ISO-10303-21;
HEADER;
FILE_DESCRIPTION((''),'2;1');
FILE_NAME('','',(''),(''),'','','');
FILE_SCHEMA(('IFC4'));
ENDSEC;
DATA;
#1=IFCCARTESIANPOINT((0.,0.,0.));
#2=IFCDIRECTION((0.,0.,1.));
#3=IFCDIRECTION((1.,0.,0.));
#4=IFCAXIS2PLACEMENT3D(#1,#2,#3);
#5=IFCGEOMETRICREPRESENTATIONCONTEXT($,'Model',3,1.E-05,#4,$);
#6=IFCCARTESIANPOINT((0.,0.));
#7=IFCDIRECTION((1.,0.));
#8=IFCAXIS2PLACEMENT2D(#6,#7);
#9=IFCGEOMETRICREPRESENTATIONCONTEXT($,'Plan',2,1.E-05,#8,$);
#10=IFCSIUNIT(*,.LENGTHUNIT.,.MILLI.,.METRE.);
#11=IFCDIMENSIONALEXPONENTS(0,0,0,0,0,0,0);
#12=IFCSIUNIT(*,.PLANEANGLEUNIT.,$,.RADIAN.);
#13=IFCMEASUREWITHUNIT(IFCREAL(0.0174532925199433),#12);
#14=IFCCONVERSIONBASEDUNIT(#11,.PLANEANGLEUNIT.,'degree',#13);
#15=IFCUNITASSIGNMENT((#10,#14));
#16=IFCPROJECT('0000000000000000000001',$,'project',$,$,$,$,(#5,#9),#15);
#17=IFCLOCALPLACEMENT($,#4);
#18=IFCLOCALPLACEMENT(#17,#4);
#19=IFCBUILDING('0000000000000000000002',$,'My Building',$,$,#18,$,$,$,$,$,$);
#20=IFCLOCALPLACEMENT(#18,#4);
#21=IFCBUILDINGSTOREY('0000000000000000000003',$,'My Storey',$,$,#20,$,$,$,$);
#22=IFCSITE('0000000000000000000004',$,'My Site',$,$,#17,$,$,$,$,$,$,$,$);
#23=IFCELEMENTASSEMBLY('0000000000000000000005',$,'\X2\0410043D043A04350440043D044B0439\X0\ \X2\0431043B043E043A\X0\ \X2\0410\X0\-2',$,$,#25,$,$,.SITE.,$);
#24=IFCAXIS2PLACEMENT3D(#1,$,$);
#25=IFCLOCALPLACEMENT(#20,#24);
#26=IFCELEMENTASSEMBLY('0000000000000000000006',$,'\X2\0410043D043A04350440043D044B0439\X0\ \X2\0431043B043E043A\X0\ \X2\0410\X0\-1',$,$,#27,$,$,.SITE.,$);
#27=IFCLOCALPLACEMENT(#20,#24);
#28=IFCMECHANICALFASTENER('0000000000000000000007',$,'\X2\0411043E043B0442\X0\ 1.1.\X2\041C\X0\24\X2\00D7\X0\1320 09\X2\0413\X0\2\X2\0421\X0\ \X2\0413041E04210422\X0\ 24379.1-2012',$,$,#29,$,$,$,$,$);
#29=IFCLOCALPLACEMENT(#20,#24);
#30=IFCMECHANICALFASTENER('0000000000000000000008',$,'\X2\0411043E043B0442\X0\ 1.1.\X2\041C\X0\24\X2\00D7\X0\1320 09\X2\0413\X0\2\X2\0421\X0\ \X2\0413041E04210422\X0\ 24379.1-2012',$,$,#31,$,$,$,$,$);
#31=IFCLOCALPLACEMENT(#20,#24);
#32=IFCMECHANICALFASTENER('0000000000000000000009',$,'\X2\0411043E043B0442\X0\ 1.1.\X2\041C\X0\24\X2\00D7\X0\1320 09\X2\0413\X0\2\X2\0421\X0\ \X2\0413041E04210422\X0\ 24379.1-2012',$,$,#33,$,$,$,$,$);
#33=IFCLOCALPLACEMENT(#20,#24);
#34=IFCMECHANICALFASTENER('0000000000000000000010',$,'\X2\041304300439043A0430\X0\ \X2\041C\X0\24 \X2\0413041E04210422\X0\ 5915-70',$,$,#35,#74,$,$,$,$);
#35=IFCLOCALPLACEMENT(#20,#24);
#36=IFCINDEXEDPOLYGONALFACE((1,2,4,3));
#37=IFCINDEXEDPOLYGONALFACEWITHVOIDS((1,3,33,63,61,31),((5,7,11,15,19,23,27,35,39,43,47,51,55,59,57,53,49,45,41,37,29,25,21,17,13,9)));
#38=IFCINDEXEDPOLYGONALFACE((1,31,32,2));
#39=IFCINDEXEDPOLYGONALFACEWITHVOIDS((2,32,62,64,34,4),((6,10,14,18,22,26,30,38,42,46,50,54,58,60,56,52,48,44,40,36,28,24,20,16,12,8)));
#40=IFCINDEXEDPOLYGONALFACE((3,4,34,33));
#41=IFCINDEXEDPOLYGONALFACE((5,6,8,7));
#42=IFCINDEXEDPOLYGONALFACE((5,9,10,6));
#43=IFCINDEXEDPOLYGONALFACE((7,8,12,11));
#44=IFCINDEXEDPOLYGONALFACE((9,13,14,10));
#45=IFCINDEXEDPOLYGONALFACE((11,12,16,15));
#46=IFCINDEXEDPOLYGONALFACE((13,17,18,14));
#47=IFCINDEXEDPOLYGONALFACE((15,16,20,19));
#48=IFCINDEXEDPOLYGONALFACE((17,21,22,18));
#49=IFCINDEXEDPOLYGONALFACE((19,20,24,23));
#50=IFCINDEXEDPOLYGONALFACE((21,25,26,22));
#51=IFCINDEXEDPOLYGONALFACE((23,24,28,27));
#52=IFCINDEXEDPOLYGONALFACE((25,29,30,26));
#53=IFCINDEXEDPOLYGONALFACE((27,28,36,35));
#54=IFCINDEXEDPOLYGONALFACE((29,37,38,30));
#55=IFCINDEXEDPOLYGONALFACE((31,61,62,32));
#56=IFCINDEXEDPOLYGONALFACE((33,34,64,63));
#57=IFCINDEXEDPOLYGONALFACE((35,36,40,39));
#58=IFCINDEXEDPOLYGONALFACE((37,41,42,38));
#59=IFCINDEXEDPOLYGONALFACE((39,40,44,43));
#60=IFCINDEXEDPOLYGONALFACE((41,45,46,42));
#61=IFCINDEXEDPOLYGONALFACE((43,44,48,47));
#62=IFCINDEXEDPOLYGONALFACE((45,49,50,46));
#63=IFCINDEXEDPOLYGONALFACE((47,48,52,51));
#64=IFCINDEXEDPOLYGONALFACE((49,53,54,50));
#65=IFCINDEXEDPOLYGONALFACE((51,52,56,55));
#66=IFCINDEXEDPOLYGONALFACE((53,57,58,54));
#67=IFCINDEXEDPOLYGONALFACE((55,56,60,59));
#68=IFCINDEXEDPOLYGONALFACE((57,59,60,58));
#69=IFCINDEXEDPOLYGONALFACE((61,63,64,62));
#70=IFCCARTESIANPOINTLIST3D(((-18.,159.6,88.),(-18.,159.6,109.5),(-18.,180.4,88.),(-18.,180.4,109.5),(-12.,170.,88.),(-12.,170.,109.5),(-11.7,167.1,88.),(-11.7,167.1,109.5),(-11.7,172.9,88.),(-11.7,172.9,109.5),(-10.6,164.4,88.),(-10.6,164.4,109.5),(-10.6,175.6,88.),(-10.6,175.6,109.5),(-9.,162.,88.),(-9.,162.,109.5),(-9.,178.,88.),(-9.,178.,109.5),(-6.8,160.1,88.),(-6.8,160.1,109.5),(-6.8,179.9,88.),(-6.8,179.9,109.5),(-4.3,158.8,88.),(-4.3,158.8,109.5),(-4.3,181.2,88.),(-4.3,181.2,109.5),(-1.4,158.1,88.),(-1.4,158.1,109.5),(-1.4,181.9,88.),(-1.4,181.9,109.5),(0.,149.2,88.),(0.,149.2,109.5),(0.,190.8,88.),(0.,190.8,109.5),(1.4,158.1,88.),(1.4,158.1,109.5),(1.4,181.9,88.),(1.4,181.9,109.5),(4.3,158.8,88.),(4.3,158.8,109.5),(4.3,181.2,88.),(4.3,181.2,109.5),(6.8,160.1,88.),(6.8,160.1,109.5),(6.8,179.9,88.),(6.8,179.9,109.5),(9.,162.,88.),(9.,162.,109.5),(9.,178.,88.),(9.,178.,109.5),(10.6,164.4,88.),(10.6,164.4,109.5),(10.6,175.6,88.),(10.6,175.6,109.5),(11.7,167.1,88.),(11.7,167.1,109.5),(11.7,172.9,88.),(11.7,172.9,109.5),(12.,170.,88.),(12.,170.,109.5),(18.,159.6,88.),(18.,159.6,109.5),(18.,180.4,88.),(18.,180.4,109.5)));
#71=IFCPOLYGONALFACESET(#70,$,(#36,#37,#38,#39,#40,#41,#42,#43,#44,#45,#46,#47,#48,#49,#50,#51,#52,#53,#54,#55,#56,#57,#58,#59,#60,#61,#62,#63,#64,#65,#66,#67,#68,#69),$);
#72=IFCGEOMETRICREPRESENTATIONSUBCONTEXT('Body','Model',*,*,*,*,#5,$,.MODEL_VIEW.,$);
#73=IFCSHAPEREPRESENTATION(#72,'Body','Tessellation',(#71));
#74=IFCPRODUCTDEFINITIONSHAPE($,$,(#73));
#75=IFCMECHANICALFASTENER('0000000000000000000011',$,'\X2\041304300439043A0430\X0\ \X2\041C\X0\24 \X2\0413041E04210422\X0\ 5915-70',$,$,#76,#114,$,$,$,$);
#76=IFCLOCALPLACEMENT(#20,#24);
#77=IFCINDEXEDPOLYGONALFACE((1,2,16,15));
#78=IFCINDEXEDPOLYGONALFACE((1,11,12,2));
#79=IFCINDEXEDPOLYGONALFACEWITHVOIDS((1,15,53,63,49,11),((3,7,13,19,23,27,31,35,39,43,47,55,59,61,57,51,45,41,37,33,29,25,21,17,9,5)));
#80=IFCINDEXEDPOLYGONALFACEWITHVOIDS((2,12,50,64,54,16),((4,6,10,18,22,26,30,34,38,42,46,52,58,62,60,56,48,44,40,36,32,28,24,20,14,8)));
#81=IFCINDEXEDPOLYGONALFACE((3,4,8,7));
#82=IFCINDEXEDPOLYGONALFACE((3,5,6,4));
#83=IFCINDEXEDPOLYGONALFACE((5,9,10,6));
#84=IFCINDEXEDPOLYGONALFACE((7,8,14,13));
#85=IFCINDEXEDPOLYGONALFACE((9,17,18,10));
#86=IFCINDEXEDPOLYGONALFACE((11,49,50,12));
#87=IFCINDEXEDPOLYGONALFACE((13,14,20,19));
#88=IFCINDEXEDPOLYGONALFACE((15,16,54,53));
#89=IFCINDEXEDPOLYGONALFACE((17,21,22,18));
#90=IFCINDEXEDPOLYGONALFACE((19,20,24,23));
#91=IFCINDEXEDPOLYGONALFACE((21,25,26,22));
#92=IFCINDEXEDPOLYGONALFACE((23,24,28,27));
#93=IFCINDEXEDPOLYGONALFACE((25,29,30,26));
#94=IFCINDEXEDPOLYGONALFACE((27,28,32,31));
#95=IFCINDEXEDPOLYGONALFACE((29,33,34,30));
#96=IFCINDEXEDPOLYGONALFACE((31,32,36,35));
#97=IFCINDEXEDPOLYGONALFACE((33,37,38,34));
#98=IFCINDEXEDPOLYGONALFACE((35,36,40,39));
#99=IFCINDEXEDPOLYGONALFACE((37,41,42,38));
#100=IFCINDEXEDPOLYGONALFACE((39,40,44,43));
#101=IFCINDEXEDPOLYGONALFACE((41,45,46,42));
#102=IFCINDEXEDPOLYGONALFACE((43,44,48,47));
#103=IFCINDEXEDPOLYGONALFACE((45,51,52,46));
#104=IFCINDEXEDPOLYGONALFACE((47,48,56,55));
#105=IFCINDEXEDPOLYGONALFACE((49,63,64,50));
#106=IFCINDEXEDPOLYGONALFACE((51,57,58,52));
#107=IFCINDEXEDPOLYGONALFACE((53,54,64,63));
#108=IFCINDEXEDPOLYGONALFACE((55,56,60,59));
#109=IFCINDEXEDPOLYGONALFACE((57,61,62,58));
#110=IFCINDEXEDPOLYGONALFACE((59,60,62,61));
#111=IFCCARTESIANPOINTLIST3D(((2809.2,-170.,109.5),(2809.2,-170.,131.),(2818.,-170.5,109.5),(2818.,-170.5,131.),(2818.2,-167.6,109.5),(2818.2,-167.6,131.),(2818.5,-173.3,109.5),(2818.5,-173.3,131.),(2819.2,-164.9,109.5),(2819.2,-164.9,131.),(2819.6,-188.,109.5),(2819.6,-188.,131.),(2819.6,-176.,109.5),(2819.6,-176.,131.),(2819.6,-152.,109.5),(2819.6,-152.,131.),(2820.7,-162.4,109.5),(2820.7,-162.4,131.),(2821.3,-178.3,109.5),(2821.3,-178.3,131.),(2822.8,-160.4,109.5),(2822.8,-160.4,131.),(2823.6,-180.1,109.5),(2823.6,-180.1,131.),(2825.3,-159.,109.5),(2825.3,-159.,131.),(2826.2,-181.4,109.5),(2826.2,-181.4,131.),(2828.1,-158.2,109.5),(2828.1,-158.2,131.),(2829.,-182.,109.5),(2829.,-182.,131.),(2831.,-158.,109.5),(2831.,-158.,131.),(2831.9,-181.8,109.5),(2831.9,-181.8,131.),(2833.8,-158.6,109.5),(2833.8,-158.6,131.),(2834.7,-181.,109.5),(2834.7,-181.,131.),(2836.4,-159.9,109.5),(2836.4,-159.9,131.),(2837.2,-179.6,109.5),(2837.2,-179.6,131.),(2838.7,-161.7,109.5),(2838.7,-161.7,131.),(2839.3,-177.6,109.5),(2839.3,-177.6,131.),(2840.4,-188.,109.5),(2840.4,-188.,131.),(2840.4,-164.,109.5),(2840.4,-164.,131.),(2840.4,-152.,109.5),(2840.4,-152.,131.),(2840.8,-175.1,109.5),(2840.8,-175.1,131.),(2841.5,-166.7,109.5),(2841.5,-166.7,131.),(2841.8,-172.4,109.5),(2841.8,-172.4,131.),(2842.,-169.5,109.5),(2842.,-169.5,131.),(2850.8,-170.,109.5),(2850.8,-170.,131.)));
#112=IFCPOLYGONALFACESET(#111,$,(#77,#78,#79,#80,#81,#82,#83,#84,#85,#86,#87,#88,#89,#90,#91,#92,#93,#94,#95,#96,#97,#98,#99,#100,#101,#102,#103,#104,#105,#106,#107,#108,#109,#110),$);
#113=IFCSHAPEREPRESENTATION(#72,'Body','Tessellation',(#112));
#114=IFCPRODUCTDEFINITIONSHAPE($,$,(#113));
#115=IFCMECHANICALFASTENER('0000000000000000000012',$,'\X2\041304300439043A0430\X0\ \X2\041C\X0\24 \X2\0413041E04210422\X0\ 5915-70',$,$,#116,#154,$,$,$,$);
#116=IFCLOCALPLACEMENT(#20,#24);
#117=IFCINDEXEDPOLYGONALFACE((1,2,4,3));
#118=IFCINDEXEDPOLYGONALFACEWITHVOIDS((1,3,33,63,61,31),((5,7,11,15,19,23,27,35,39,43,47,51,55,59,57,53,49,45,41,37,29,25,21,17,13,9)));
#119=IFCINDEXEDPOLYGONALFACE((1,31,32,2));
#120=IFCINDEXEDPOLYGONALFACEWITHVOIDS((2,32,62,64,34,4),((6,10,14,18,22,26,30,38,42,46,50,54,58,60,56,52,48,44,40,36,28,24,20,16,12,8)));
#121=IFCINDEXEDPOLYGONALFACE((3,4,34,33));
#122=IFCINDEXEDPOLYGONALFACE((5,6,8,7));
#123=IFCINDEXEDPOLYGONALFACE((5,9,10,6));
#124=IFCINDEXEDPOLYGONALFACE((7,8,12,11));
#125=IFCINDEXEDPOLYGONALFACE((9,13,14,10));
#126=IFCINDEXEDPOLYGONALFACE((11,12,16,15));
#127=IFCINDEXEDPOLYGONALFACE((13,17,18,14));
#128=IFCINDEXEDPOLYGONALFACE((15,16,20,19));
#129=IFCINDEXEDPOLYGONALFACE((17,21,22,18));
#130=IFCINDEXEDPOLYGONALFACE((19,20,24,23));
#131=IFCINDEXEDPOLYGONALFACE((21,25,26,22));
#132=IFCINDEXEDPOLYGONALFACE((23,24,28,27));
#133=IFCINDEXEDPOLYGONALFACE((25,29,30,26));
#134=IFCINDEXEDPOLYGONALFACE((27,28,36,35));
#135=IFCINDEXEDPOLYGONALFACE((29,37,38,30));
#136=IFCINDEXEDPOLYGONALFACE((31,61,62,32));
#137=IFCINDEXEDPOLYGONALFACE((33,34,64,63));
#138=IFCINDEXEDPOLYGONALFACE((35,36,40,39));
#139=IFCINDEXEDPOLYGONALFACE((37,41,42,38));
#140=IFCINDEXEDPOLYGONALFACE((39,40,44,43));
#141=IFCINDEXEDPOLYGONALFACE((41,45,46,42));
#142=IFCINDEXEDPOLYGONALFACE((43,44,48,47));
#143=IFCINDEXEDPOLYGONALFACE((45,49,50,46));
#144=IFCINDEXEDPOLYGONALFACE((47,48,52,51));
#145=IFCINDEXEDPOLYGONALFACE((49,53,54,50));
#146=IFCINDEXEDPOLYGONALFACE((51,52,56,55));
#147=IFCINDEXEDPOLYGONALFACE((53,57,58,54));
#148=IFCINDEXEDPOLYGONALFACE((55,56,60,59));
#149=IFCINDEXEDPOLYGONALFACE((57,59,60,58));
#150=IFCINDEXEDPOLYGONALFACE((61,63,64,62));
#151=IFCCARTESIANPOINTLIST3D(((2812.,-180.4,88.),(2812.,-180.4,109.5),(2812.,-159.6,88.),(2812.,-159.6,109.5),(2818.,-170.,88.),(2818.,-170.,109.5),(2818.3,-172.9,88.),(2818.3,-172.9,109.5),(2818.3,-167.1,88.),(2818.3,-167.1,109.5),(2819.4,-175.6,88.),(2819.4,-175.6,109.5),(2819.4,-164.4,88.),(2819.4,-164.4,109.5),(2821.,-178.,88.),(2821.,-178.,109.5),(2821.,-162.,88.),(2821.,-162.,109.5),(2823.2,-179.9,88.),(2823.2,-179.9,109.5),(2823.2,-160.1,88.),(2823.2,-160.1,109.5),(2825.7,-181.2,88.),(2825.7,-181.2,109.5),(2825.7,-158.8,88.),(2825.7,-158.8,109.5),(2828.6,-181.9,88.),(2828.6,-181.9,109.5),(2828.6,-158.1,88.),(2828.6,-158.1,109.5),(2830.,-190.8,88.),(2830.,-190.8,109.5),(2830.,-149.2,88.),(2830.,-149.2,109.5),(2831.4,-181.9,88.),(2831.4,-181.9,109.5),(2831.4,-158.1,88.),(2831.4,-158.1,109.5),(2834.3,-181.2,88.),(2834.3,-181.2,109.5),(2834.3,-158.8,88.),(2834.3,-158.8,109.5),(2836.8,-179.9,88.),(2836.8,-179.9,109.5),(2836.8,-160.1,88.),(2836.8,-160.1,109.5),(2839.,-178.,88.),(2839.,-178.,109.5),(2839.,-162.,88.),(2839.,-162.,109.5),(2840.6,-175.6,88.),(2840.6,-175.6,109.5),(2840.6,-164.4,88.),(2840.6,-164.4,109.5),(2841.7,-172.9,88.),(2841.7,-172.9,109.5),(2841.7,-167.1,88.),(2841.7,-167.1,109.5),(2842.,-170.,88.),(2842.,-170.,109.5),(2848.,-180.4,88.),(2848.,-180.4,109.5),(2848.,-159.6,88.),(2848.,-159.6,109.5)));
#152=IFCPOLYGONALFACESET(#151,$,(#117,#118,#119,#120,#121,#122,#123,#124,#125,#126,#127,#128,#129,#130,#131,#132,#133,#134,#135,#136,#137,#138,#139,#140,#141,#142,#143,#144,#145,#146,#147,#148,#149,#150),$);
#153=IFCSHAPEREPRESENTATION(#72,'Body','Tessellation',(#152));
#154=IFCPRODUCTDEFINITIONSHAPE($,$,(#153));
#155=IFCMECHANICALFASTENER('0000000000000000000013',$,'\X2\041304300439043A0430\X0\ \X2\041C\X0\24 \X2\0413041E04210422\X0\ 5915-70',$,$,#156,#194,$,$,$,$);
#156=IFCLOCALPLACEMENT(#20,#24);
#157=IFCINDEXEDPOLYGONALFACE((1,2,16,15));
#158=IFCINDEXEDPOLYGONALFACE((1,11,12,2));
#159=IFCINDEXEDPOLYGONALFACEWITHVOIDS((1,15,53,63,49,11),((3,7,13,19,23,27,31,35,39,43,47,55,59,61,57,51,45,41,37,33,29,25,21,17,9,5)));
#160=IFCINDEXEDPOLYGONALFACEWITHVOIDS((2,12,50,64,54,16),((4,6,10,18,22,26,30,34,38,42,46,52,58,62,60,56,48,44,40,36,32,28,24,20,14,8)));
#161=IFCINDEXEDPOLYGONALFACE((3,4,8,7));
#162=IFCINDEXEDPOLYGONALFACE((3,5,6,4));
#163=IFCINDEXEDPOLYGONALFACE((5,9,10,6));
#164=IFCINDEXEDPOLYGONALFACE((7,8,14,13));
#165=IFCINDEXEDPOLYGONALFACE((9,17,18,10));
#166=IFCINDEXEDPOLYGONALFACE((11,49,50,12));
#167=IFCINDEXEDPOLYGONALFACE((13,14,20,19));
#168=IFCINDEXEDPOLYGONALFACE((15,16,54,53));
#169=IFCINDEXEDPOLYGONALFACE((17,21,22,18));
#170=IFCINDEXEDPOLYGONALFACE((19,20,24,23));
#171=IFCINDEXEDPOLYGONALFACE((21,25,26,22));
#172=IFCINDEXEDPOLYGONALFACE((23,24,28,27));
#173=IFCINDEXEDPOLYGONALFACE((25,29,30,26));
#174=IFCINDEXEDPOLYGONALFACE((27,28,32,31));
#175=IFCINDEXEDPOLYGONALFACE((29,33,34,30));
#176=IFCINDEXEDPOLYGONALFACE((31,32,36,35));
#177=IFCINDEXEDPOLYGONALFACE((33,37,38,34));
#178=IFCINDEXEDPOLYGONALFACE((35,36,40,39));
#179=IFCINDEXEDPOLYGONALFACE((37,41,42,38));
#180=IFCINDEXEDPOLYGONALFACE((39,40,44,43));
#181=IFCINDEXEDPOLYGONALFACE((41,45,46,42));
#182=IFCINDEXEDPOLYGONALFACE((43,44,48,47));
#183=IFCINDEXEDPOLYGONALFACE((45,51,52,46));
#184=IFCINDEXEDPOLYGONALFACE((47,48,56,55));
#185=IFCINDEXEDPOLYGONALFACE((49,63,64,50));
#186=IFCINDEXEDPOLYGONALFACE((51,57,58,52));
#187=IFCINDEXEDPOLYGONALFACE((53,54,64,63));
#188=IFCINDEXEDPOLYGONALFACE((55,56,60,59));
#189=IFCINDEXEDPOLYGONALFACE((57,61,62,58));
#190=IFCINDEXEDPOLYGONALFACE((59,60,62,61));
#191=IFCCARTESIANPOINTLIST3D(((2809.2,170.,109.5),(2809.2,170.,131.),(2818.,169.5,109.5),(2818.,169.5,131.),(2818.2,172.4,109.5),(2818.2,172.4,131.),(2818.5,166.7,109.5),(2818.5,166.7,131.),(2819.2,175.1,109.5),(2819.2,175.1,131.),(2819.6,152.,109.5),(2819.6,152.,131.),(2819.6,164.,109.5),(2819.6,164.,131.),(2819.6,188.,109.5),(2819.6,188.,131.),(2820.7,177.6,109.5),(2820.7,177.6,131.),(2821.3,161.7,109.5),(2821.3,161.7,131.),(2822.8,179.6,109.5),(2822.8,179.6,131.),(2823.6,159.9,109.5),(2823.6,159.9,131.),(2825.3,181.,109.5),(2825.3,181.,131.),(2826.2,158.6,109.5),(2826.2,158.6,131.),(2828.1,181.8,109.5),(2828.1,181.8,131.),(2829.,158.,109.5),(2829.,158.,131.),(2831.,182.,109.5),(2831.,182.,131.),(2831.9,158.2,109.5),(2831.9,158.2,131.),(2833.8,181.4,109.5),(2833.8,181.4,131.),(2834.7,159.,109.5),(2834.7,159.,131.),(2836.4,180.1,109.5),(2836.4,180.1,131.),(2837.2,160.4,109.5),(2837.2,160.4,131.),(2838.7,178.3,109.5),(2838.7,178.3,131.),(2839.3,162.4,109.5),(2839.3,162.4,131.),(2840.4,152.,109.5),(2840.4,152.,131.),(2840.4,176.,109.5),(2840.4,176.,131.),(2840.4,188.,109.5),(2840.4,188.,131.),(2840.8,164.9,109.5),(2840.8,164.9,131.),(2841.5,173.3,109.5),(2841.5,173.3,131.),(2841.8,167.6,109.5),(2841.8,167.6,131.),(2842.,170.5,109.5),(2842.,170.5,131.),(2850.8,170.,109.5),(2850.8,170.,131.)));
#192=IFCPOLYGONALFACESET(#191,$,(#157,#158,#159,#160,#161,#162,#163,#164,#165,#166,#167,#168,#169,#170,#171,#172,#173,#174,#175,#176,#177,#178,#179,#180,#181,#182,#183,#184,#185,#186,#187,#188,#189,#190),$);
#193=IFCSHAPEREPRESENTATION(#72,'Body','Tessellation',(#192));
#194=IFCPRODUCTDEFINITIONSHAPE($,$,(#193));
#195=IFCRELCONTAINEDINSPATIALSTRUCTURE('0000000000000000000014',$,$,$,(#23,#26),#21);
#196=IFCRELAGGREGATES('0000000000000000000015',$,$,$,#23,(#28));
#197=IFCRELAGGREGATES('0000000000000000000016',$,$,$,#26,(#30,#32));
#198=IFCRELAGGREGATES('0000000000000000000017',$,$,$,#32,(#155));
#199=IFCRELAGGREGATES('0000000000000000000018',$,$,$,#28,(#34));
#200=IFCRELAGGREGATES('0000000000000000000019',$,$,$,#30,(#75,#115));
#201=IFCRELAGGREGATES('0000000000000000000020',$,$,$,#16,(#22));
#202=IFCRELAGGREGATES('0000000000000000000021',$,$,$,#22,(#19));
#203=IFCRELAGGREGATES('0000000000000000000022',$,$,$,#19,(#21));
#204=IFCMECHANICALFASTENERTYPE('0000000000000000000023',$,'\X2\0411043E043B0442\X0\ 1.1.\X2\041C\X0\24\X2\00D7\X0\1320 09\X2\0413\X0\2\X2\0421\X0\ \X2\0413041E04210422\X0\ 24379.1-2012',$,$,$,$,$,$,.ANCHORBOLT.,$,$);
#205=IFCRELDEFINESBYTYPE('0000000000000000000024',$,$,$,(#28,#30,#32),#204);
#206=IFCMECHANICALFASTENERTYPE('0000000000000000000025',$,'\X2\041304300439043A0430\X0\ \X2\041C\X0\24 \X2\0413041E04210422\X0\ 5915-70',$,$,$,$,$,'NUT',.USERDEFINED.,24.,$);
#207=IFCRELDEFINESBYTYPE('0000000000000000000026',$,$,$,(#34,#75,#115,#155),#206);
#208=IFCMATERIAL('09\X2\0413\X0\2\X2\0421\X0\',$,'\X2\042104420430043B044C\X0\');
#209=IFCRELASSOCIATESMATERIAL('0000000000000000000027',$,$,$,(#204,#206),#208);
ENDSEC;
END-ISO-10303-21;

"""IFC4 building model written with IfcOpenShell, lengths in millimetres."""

from ifc_helpers import new_model, entity, si_unit, converted_unit, frame, origin_with_axes, origin_2d_with_axis, place, context, subcontext, project, spatial, polyline, outline, extrude, source, transform, mapped, material, type_object, type_shapes, element, aggregate, save


model = new_model("IFC4")

# Units and contexts
model_context = context("Model", 3, precision=1e-05, world=origin_with_axes())
plan_context = context("Plan", 2, precision=1e-05, world=origin_2d_with_axis())
body_context = subcontext(model_context, "Body", "Model", "MODEL_VIEW")
ifc_project = project(units=[si_unit("LENGTHUNIT", "METRE", prefix="MILLI"), converted_unit("PLANEANGLEUNIT", "degree", entity("IfcReal", 0.0174532925199433), si_unit("PLANEANGLEUNIT", "RADIAN"), dimensions=[0, 0, 0, 0, 0, 0, 0])], contexts=[model_context, plan_context])

# Site, building, storey
site_placement = place(None, origin_with_axes())
site = spatial("IfcSite", under=ifc_project, at=site_placement, Name="My Site")
building_placement = place(site_placement, origin_with_axes())
building = spatial("IfcBuilding", under=site, at=building_placement, Name="My Building")
storey_placement = place(building_placement, origin_with_axes())
storey = spatial("IfcBuildingStorey", under=building, at=storey_placement, Name="My Storey")

# Element assemblies
placement_1 = place(storey_placement, origin_with_axes())
assembly_1 = element("IfcElementAssembly", 1, at=placement_1, inside=storey, Name="Анкерный блок А-2", AssemblyPlace="SITE")
placement_2 = place(storey_placement, frame((3000.0, 0.0, 0.0), z_axis=(0.0, 0.0, 1.0), x_axis=(1.0, 0.0, 0.0)))
assembly_2 = element("IfcElementAssembly", 2, at=placement_2, inside=storey, Name="Анкерный блок А-1", AssemblyPlace="SITE")

# Shared definitions
ifc_material_1 = material(Name="09Г2С", Category="Сталь")
mechanical_fastener_type_1 = type_object("IfcMechanicalFastenerType", Name="Болт 1.1.М24×1320 09Г2С ГОСТ 24379.1-2012", PredefinedType="ANCHORBOLT", material=ifc_material_1)

# Mechanical fastener
mechanical_fastener_1_placement = place(placement_1, frame((0.0, 170.0, 0.0), z_axis=(0.0, 0.0, 1.0), x_axis=(-1.0, 0.0, 0.0)))
mechanical_fastener_1 = element("IfcMechanicalFastener", 3, at=mechanical_fastener_1_placement, type_object=mechanical_fastener_type_1, Name="Болт 1.1.М24×1320 09Г2С ГОСТ 24379.1-2012")
aggregate(assembly_1, [mechanical_fastener_1])

# Mechanical fasteners
mechanical_fastener_2_placement = place(placement_2, frame((-170.0, -170.0, 0.0), z_axis=(0.0, 0.0, 1.0), x_axis=(1.0, 0.0, 0.0)))
mechanical_fastener_2 = element("IfcMechanicalFastener", 4, at=mechanical_fastener_2_placement, type_object=mechanical_fastener_type_1, Name="Болт 1.1.М24×1320 09Г2С ГОСТ 24379.1-2012")
mechanical_fastener_3_placement = place(placement_2, frame((-170.0, 170.0, 0.0), z_axis=(0.0, 0.0, 1.0), x_axis=(-1.0, 0.0, 0.0)))
mechanical_fastener_3 = element("IfcMechanicalFastener", 5, at=mechanical_fastener_3_placement, type_object=mechanical_fastener_type_1, Name="Болт 1.1.М24×1320 09Г2С ГОСТ 24379.1-2012")

# Mechanical fasteners
aggregate(assembly_2, [mechanical_fastener_2, mechanical_fastener_3])
mechanical_fastener_type_2 = type_object("IfcMechanicalFastenerType", Name="Гайка М24 ГОСТ 5915-70", ElementType="NUT", NominalDiameter=24.0, PredefinedType="USERDEFINED", material=ifc_material_1)
shared_shape_1 = source(origin_with_axes(), body_context, "Body", "SweptSolid", [
    extrude(outline(polyline([(-10.4, -18.0), (10.4, -18.0), (20.8, 0.0), (10.4, 18.0), (-10.4, 18.0), (-20.8, 0.0), (-10.4, -18.0)]), holes=[polyline([(-8.0, 9.0), (-5.6, 10.6), (-2.9, 11.7), (0.0, 12.0), (2.9, 11.7), (5.6, 10.6), (8.0, 9.0), (9.9, 6.8), (11.2, 4.3), (11.9, 1.4), (11.9, -1.4), (11.2, -4.3), (9.9, -6.8), (8.0, -9.0), (5.6, -10.6), (2.9, -11.7), (0.0, -12.0), (-2.9, -11.7), (-5.6, -10.6), (-8.0, -9.0), (-9.9, -6.8), (-11.2, -4.3), (-11.9, -1.4), (-11.9, 1.4), (-11.2, 4.3), (-9.9, 6.8), (-8.0, 9.0)])]), frame((0.0, 0.0, 0.0), z_axis=(0.0, 0.0, 1.0), x_axis=(0.0, 1.0, 0.0)), (0.0, 0.0, 1.0), 21.5),
])
type_shapes(mechanical_fastener_type_2, [shared_shape_1])
mechanical_fastener_4_placement = place(mechanical_fastener_1_placement, frame((0.0, 0.0, 88.0), z_axis=(0.0, 0.0, 1.0), x_axis=(1.0, 0.0, 0.0)))
mechanical_fastener_4 = element("IfcMechanicalFastener", 6, at=mechanical_fastener_4_placement, type_object=mechanical_fastener_type_2, Name="Гайка М24 ГОСТ 5915-70", context=body_context, shape_type="MappedRepresentation", body=[
    mapped(shared_shape_1, transform((0.0, 0.0, 0.0), x_axis=(1.0, 0.0, 0.0), y_axis=(0.0, 1.0, 0.0), z_axis=(0.0, 0.0, 1.0), scale=1.0)),
])
mechanical_fastener_5_placement = place(mechanical_fastener_2_placement, frame((0.0, 0.0, 109.5), z_axis=(0.0, 0.0, 1.0), x_axis=(0.866025, 0.5, 0.0)))
mechanical_fastener_5 = element("IfcMechanicalFastener", 7, at=mechanical_fastener_5_placement, type_object=mechanical_fastener_type_2, Name="Гайка М24 ГОСТ 5915-70", context=body_context, shape_type="MappedRepresentation", body=[
    mapped(shared_shape_1, transform((0.0, 0.0, 0.0), x_axis=(1.0, 0.0, 0.0), y_axis=(0.0, 1.0, 0.0), z_axis=(0.0, 0.0, 1.0), scale=1.0)),
])
mechanical_fastener_6_placement = place(mechanical_fastener_2_placement, frame((0.0, 0.0, 88.0), z_axis=(0.0, 0.0, 1.0), x_axis=(1.0, 0.0, 0.0)))
mechanical_fastener_6 = element("IfcMechanicalFastener", 8, at=mechanical_fastener_6_placement, type_object=mechanical_fastener_type_2, Name="Гайка М24 ГОСТ 5915-70", context=body_context, shape_type="MappedRepresentation", body=[
    mapped(shared_shape_1, transform((0.0, 0.0, 0.0), x_axis=(1.0, 0.0, 0.0), y_axis=(0.0, 1.0, 0.0), z_axis=(0.0, 0.0, 1.0), scale=1.0)),
])
mechanical_fastener_7_placement = place(mechanical_fastener_3_placement, frame((0.0, 0.0, 109.5), z_axis=(0.0, 0.0, 1.0), x_axis=(0.866025, 0.5, 0.0)))
mechanical_fastener_7 = element("IfcMechanicalFastener", 9, at=mechanical_fastener_7_placement, type_object=mechanical_fastener_type_2, Name="Гайка М24 ГОСТ 5915-70", context=body_context, shape_type="MappedRepresentation", body=[
    mapped(shared_shape_1, transform((0.0, 0.0, 0.0), x_axis=(1.0, 0.0, 0.0), y_axis=(0.0, 1.0, 0.0), z_axis=(0.0, 0.0, 1.0), scale=1.0)),
])
aggregate(mechanical_fastener_3, [mechanical_fastener_7])
aggregate(mechanical_fastener_1, [mechanical_fastener_4])
aggregate(mechanical_fastener_2, [mechanical_fastener_5, mechanical_fastener_6])

save(model, "model.ifc")
